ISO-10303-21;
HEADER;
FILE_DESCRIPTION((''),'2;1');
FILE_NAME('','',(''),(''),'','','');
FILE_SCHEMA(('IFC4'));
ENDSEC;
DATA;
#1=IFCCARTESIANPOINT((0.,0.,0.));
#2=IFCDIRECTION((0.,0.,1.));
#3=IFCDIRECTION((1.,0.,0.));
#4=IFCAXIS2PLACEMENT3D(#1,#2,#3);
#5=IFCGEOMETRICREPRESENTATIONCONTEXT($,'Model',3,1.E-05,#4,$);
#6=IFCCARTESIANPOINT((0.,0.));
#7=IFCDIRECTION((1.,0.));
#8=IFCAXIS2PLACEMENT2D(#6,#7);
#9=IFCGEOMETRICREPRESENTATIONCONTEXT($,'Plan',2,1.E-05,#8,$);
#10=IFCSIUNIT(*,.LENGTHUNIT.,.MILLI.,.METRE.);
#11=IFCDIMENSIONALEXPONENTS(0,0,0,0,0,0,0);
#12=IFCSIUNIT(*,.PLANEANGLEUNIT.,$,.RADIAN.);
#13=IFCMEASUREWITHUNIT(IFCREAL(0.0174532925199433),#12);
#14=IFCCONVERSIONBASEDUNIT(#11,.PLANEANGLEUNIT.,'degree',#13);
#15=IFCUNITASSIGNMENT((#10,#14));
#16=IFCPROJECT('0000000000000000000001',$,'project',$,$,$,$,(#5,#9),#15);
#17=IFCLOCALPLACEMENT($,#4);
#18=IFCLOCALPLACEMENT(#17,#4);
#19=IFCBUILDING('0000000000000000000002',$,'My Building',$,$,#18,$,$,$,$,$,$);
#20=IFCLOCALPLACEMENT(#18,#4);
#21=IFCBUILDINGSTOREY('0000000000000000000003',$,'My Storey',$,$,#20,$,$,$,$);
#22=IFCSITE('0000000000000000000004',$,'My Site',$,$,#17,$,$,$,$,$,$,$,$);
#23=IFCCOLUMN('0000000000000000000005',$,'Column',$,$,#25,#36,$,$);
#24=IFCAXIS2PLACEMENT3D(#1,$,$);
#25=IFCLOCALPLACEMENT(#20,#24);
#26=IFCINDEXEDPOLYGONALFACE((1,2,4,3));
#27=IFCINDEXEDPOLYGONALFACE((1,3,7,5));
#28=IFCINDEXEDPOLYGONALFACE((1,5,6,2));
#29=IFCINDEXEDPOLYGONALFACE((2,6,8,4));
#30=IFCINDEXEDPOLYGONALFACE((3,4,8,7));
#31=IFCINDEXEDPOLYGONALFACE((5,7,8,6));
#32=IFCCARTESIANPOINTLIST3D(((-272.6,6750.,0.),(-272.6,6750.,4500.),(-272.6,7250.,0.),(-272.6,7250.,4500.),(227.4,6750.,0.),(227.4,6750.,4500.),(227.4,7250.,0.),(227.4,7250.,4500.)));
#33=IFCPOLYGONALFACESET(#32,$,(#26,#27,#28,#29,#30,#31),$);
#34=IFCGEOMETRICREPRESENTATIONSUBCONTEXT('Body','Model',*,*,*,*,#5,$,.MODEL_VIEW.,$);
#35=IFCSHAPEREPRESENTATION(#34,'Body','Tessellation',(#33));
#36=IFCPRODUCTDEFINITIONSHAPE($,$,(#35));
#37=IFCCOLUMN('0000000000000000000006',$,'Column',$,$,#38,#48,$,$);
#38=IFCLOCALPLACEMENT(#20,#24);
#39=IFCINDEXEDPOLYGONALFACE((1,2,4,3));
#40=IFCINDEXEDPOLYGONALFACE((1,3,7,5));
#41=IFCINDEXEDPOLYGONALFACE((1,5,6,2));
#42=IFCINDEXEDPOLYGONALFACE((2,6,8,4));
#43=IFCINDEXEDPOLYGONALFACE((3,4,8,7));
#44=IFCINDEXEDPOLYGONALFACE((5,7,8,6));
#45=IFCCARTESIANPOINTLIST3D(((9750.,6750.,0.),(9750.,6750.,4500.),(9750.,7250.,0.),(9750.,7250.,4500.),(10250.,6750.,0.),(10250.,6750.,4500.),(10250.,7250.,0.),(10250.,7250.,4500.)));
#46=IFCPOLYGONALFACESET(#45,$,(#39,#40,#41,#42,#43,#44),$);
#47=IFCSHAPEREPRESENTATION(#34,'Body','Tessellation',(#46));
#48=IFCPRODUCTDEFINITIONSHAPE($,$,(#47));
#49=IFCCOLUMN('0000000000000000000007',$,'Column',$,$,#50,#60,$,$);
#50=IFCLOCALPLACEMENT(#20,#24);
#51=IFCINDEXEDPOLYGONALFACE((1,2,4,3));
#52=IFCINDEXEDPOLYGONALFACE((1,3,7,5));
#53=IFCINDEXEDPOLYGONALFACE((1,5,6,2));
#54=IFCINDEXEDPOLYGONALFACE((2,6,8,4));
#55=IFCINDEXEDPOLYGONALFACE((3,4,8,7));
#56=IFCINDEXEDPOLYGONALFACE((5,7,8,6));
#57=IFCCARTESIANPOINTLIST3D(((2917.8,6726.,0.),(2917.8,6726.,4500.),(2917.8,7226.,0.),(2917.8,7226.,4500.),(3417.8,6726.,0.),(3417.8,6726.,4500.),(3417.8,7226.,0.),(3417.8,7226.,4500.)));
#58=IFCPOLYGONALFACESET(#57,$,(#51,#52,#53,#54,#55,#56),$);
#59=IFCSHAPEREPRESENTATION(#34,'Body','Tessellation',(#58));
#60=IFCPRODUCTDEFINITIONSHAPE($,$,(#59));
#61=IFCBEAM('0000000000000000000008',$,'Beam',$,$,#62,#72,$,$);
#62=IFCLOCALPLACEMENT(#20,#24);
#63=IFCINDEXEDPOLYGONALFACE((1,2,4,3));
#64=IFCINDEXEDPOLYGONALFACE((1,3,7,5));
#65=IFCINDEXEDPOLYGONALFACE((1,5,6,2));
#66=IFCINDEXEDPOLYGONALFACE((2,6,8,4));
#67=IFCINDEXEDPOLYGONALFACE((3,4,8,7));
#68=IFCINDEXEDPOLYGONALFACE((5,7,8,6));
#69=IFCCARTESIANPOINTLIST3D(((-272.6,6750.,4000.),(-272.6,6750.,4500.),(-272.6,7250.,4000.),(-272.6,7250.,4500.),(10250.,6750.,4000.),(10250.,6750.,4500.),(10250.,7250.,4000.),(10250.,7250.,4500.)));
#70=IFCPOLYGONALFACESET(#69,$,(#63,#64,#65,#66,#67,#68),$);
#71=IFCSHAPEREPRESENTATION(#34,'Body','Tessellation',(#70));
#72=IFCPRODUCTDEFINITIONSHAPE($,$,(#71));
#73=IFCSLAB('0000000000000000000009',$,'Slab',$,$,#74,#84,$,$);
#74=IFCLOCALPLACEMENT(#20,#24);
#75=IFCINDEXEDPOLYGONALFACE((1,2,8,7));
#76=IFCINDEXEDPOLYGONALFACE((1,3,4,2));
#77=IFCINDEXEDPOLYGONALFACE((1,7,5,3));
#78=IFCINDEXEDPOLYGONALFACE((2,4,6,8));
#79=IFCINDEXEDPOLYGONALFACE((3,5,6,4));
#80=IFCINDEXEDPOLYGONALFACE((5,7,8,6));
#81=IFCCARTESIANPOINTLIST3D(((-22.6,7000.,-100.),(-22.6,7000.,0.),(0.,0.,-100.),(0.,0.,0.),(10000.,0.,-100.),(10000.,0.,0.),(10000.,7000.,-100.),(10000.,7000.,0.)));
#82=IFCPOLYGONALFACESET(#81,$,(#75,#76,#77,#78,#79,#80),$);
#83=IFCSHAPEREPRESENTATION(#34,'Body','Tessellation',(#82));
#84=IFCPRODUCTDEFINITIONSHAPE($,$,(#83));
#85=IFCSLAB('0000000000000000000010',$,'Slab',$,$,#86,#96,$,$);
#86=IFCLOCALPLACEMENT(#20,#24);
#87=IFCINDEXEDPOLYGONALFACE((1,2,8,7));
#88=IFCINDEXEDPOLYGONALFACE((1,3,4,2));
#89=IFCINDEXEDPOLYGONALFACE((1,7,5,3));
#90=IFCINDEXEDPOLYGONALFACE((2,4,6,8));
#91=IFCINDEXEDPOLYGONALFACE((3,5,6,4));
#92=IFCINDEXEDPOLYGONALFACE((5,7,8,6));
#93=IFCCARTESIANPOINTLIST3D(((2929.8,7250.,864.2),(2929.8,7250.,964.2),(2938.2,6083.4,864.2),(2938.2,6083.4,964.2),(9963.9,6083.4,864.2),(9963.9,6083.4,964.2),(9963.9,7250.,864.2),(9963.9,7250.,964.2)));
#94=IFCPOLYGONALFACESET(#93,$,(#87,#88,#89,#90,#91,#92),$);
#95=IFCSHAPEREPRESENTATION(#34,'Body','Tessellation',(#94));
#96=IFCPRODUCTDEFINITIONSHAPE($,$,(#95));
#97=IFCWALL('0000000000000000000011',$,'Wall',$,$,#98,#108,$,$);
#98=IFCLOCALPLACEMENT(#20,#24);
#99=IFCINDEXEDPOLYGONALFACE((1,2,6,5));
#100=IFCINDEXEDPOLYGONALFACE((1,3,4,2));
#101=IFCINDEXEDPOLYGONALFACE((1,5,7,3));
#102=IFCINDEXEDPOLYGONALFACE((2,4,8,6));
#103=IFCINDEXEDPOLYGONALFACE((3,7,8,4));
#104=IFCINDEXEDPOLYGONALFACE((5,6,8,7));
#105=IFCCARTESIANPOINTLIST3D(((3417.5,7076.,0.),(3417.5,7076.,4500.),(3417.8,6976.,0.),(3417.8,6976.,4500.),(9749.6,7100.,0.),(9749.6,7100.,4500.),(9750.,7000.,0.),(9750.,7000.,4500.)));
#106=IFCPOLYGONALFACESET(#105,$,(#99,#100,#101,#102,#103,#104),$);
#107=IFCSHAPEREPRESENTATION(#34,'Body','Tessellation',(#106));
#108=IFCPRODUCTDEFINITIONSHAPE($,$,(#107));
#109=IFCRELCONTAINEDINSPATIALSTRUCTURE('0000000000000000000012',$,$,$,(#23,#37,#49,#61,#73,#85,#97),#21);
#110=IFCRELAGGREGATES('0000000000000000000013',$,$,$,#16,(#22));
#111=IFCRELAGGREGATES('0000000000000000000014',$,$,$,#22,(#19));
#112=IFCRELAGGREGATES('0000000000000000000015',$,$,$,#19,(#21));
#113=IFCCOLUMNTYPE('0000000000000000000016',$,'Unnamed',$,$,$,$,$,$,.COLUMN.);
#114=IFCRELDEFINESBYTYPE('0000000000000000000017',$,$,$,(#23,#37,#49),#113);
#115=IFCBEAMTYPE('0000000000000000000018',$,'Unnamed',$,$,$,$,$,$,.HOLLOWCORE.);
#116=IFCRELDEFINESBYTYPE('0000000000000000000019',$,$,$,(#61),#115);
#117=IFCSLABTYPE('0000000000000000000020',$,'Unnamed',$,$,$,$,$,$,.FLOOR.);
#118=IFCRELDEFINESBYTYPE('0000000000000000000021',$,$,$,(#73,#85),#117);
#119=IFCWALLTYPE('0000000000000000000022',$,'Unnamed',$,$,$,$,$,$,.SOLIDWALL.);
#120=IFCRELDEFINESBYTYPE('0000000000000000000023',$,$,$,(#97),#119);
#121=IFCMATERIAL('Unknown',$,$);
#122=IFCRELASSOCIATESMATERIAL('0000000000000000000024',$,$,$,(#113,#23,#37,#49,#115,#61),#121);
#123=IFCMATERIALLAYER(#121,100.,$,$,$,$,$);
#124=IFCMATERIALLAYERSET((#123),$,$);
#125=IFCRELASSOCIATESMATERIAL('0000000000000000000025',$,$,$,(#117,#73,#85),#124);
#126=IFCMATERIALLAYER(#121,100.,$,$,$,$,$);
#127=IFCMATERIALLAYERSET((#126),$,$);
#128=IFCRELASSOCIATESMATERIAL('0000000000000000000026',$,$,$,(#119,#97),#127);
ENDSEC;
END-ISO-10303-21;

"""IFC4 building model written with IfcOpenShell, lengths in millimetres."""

from ifc_helpers import new_model, entity, si_unit, converted_unit, frame, origin_with_axes, origin_2d_with_axis, place, context, subcontext, project, spatial, line, indexed_curve, rectangle, outline, extrude, material, layer, layer_set, layer_usage, material_profile, profile_set, profile_usage, type_object, element, save


model = new_model("IFC4")

# Units and contexts
model_context = context("Model", 3, precision=1e-05, world=origin_with_axes())
plan_context = context("Plan", 2, precision=1e-05, world=origin_2d_with_axis())
body_context = subcontext(model_context, "Body", "Model", "MODEL_VIEW")
ifc_project = project(units=[si_unit("LENGTHUNIT", "METRE", prefix="MILLI"), converted_unit("PLANEANGLEUNIT", "degree", entity("IfcReal", 0.0174532925199433), si_unit("PLANEANGLEUNIT", "RADIAN"), dimensions=[0, 0, 0, 0, 0, 0, 0])], contexts=[model_context, plan_context])

# Site, building, storey
site_placement = place(None, origin_with_axes())
site = spatial("IfcSite", under=ifc_project, at=site_placement, Name="My Site")
building_placement = place(site_placement, origin_with_axes())
building = spatial("IfcBuilding", under=site, at=building_placement, Name="My Building")
storey_placement = place(building_placement, origin_with_axes())
storey = spatial("IfcBuildingStorey", under=building, at=storey_placement, Name="My Storey")

# Columns
ifc_material = material(Name="Unknown")
ifc_material_profile_1 = material_profile(ifc_material, rectangle(XDim=500.0, YDim=500.0))
ifc_profile_set_1 = profile_set([ifc_material_profile_1])
ifc_profile_usage_1 = profile_usage(ifc_profile_set_1, cardinal=5)
column_type = type_object("IfcColumnType", Name="Unnamed", PredefinedType="COLUMN", material=ifc_profile_set_1)
column_1_placement = place(storey_placement, frame((-22.6, 7000.0, 0.0), z_axis=(0.0, 0.0, 1.0), x_axis=(1.0, 0.0, 0.0)))
element("IfcColumn", 1, at=column_1_placement, inside=storey, type_object=column_type, material=ifc_profile_usage_1, Name="Column", context=body_context, shape_type="SweptSolid", body=[
    extrude(rectangle(XDim=500.0, YDim=500.0), origin_with_axes(), (0.0, 0.0, 1.0), 4500.0),
])
ifc_profile_usage_2 = profile_usage(ifc_profile_set_1, cardinal=5)
column_2_placement = place(storey_placement, frame((10000.0, 7000.0, 0.0), z_axis=(0.0, 0.0, 1.0), x_axis=(1.0, 0.0, 0.0)))
element("IfcColumn", 2, at=column_2_placement, inside=storey, type_object=column_type, material=ifc_profile_usage_2, Name="Column", context=body_context, shape_type="SweptSolid", body=[
    extrude(rectangle(XDim=500.0, YDim=500.0), origin_with_axes(), (0.0, 0.0, 1.0), 4500.0),
])
ifc_profile_usage_3 = profile_usage(ifc_profile_set_1, cardinal=5)
column_3_placement = place(storey_placement, frame((3167.8, 6976.0, 0.0), z_axis=(0.0, 0.0, 1.0), x_axis=(1.0, 0.0, 0.0)))
element("IfcColumn", 3, at=column_3_placement, inside=storey, type_object=column_type, material=ifc_profile_usage_3, Name="Column", context=body_context, shape_type="SweptSolid", body=[
    extrude(rectangle(XDim=500.0, YDim=500.0), origin_with_axes(), (0.0, 0.0, 1.0), 4500.0),
])

# Beam
ifc_material_profile_2 = material_profile(ifc_material, rectangle(XDim=500.0, YDim=500.0))
ifc_profile_set_2 = profile_set([ifc_material_profile_2])
ifc_profile_usage_4 = profile_usage(ifc_profile_set_2, cardinal=9)
beam_type = type_object("IfcBeamType", Name="Unnamed", PredefinedType="HOLLOWCORE", material=ifc_profile_set_2)
beam_placement = place(storey_placement, frame((-272.6, 6750.0, 4500.0), z_axis=(1.0, 0.0, 0.0), x_axis=(0.0, 1.0, 0.0)))
element("IfcBeam", 4, at=beam_placement, inside=storey, type_object=beam_type, material=ifc_profile_usage_4, Name="Beam", context=body_context, shape_type="SweptSolid", body=[
    extrude(rectangle(XDim=500.0, YDim=500.0), frame((250.0, -250.0, 0.0), z_axis=(0.0, 0.0, 1.0), x_axis=(1.0, 0.0, 0.0)), (0.0, 0.0, 1.0), 10522.6),
])

# Slabs
ifc_layer_1 = layer(ifc_material, 100.0)
ifc_layer_set_1 = layer_set([ifc_layer_1])
ifc_layer_usage_1 = layer_usage(ifc_layer_set_1, "AXIS3", "POSITIVE", -100.0)
slab_type = type_object("IfcSlabType", Name="Unnamed", PredefinedType="FLOOR", material=ifc_layer_set_1)
slab_1_placement = place(storey_placement, frame((-22.6, 7000.0, 0.0), z_axis=(0.0, 0.0, 1.0), x_axis=(1.0, 0.0, 0.0)))
element("IfcSlab", 5, at=slab_1_placement, inside=storey, type_object=slab_type, material=ifc_layer_usage_1, Name="Slab", context=body_context, shape_type="SweptSolid", body=[
    extrude(outline(indexed_curve([(0.0, 0.0), (10022.6, 0.0), (10022.6, -7000.0), (22.6, -7000.0), (0.0, 0.0)])), frame((0.0, 0.0, -100.0), z_axis=(0.0, 0.0, 1.0), x_axis=(1.0, 0.0, 0.0)), (0.0, 0.0, 1.0), 100.0),
])
ifc_layer_usage_2 = layer_usage(ifc_layer_set_1, "AXIS3", "POSITIVE", -100.0)
slab_2_placement = place(storey_placement, frame((2929.8, 7250.0, 964.2), z_axis=(0.0, 0.0, 1.0), x_axis=(1.0, 0.0, 0.0)))
element("IfcSlab", 6, at=slab_2_placement, inside=storey, type_object=slab_type, material=ifc_layer_usage_2, Name="Slab", context=body_context, shape_type="SweptSolid", body=[
    extrude(outline(indexed_curve([(0.0, 0.0), (7034.2, 0.0), (7034.2, -1166.6), (8.4, -1166.6), (0.0, 0.0)])), frame((0.0, 0.0, -100.0), z_axis=(0.0, 0.0, 1.0), x_axis=(1.0, 0.0, 0.0)), (0.0, 0.0, 1.0), 100.0),
])

# Wall
ifc_layer_2 = layer(ifc_material, 100.0)
ifc_layer_set_2 = layer_set([ifc_layer_2])
ifc_layer_usage_3 = layer_usage(ifc_layer_set_2, "AXIS2", "POSITIVE", 0.0)
wall_type = type_object("IfcWallType", Name="Unnamed", PredefinedType="SOLIDWALL", material=ifc_layer_set_2)
wall_placement = place(storey_placement, frame((3417.8, 6976.0, 0.0), z_axis=(0.0, 0.0, 1.0), x_axis=(0.999993, 0.003789, 0.0)))
element("IfcWall", 7, at=wall_placement, inside=storey, type_object=wall_type, material=ifc_layer_usage_3, Name="Wall", context=body_context, shape_type="SweptSolid", body=[
    extrude(outline(indexed_curve([(0.0, 0.0), (0.0, 100.0), (6332.2, 100.0), (6332.2, 0.0)], segments=[line(1, 2, 3, 4, 1)])), origin_with_axes(), (0.0, 0.0, 1.0), 4500.0),
])

save(model, "model.ifc")
